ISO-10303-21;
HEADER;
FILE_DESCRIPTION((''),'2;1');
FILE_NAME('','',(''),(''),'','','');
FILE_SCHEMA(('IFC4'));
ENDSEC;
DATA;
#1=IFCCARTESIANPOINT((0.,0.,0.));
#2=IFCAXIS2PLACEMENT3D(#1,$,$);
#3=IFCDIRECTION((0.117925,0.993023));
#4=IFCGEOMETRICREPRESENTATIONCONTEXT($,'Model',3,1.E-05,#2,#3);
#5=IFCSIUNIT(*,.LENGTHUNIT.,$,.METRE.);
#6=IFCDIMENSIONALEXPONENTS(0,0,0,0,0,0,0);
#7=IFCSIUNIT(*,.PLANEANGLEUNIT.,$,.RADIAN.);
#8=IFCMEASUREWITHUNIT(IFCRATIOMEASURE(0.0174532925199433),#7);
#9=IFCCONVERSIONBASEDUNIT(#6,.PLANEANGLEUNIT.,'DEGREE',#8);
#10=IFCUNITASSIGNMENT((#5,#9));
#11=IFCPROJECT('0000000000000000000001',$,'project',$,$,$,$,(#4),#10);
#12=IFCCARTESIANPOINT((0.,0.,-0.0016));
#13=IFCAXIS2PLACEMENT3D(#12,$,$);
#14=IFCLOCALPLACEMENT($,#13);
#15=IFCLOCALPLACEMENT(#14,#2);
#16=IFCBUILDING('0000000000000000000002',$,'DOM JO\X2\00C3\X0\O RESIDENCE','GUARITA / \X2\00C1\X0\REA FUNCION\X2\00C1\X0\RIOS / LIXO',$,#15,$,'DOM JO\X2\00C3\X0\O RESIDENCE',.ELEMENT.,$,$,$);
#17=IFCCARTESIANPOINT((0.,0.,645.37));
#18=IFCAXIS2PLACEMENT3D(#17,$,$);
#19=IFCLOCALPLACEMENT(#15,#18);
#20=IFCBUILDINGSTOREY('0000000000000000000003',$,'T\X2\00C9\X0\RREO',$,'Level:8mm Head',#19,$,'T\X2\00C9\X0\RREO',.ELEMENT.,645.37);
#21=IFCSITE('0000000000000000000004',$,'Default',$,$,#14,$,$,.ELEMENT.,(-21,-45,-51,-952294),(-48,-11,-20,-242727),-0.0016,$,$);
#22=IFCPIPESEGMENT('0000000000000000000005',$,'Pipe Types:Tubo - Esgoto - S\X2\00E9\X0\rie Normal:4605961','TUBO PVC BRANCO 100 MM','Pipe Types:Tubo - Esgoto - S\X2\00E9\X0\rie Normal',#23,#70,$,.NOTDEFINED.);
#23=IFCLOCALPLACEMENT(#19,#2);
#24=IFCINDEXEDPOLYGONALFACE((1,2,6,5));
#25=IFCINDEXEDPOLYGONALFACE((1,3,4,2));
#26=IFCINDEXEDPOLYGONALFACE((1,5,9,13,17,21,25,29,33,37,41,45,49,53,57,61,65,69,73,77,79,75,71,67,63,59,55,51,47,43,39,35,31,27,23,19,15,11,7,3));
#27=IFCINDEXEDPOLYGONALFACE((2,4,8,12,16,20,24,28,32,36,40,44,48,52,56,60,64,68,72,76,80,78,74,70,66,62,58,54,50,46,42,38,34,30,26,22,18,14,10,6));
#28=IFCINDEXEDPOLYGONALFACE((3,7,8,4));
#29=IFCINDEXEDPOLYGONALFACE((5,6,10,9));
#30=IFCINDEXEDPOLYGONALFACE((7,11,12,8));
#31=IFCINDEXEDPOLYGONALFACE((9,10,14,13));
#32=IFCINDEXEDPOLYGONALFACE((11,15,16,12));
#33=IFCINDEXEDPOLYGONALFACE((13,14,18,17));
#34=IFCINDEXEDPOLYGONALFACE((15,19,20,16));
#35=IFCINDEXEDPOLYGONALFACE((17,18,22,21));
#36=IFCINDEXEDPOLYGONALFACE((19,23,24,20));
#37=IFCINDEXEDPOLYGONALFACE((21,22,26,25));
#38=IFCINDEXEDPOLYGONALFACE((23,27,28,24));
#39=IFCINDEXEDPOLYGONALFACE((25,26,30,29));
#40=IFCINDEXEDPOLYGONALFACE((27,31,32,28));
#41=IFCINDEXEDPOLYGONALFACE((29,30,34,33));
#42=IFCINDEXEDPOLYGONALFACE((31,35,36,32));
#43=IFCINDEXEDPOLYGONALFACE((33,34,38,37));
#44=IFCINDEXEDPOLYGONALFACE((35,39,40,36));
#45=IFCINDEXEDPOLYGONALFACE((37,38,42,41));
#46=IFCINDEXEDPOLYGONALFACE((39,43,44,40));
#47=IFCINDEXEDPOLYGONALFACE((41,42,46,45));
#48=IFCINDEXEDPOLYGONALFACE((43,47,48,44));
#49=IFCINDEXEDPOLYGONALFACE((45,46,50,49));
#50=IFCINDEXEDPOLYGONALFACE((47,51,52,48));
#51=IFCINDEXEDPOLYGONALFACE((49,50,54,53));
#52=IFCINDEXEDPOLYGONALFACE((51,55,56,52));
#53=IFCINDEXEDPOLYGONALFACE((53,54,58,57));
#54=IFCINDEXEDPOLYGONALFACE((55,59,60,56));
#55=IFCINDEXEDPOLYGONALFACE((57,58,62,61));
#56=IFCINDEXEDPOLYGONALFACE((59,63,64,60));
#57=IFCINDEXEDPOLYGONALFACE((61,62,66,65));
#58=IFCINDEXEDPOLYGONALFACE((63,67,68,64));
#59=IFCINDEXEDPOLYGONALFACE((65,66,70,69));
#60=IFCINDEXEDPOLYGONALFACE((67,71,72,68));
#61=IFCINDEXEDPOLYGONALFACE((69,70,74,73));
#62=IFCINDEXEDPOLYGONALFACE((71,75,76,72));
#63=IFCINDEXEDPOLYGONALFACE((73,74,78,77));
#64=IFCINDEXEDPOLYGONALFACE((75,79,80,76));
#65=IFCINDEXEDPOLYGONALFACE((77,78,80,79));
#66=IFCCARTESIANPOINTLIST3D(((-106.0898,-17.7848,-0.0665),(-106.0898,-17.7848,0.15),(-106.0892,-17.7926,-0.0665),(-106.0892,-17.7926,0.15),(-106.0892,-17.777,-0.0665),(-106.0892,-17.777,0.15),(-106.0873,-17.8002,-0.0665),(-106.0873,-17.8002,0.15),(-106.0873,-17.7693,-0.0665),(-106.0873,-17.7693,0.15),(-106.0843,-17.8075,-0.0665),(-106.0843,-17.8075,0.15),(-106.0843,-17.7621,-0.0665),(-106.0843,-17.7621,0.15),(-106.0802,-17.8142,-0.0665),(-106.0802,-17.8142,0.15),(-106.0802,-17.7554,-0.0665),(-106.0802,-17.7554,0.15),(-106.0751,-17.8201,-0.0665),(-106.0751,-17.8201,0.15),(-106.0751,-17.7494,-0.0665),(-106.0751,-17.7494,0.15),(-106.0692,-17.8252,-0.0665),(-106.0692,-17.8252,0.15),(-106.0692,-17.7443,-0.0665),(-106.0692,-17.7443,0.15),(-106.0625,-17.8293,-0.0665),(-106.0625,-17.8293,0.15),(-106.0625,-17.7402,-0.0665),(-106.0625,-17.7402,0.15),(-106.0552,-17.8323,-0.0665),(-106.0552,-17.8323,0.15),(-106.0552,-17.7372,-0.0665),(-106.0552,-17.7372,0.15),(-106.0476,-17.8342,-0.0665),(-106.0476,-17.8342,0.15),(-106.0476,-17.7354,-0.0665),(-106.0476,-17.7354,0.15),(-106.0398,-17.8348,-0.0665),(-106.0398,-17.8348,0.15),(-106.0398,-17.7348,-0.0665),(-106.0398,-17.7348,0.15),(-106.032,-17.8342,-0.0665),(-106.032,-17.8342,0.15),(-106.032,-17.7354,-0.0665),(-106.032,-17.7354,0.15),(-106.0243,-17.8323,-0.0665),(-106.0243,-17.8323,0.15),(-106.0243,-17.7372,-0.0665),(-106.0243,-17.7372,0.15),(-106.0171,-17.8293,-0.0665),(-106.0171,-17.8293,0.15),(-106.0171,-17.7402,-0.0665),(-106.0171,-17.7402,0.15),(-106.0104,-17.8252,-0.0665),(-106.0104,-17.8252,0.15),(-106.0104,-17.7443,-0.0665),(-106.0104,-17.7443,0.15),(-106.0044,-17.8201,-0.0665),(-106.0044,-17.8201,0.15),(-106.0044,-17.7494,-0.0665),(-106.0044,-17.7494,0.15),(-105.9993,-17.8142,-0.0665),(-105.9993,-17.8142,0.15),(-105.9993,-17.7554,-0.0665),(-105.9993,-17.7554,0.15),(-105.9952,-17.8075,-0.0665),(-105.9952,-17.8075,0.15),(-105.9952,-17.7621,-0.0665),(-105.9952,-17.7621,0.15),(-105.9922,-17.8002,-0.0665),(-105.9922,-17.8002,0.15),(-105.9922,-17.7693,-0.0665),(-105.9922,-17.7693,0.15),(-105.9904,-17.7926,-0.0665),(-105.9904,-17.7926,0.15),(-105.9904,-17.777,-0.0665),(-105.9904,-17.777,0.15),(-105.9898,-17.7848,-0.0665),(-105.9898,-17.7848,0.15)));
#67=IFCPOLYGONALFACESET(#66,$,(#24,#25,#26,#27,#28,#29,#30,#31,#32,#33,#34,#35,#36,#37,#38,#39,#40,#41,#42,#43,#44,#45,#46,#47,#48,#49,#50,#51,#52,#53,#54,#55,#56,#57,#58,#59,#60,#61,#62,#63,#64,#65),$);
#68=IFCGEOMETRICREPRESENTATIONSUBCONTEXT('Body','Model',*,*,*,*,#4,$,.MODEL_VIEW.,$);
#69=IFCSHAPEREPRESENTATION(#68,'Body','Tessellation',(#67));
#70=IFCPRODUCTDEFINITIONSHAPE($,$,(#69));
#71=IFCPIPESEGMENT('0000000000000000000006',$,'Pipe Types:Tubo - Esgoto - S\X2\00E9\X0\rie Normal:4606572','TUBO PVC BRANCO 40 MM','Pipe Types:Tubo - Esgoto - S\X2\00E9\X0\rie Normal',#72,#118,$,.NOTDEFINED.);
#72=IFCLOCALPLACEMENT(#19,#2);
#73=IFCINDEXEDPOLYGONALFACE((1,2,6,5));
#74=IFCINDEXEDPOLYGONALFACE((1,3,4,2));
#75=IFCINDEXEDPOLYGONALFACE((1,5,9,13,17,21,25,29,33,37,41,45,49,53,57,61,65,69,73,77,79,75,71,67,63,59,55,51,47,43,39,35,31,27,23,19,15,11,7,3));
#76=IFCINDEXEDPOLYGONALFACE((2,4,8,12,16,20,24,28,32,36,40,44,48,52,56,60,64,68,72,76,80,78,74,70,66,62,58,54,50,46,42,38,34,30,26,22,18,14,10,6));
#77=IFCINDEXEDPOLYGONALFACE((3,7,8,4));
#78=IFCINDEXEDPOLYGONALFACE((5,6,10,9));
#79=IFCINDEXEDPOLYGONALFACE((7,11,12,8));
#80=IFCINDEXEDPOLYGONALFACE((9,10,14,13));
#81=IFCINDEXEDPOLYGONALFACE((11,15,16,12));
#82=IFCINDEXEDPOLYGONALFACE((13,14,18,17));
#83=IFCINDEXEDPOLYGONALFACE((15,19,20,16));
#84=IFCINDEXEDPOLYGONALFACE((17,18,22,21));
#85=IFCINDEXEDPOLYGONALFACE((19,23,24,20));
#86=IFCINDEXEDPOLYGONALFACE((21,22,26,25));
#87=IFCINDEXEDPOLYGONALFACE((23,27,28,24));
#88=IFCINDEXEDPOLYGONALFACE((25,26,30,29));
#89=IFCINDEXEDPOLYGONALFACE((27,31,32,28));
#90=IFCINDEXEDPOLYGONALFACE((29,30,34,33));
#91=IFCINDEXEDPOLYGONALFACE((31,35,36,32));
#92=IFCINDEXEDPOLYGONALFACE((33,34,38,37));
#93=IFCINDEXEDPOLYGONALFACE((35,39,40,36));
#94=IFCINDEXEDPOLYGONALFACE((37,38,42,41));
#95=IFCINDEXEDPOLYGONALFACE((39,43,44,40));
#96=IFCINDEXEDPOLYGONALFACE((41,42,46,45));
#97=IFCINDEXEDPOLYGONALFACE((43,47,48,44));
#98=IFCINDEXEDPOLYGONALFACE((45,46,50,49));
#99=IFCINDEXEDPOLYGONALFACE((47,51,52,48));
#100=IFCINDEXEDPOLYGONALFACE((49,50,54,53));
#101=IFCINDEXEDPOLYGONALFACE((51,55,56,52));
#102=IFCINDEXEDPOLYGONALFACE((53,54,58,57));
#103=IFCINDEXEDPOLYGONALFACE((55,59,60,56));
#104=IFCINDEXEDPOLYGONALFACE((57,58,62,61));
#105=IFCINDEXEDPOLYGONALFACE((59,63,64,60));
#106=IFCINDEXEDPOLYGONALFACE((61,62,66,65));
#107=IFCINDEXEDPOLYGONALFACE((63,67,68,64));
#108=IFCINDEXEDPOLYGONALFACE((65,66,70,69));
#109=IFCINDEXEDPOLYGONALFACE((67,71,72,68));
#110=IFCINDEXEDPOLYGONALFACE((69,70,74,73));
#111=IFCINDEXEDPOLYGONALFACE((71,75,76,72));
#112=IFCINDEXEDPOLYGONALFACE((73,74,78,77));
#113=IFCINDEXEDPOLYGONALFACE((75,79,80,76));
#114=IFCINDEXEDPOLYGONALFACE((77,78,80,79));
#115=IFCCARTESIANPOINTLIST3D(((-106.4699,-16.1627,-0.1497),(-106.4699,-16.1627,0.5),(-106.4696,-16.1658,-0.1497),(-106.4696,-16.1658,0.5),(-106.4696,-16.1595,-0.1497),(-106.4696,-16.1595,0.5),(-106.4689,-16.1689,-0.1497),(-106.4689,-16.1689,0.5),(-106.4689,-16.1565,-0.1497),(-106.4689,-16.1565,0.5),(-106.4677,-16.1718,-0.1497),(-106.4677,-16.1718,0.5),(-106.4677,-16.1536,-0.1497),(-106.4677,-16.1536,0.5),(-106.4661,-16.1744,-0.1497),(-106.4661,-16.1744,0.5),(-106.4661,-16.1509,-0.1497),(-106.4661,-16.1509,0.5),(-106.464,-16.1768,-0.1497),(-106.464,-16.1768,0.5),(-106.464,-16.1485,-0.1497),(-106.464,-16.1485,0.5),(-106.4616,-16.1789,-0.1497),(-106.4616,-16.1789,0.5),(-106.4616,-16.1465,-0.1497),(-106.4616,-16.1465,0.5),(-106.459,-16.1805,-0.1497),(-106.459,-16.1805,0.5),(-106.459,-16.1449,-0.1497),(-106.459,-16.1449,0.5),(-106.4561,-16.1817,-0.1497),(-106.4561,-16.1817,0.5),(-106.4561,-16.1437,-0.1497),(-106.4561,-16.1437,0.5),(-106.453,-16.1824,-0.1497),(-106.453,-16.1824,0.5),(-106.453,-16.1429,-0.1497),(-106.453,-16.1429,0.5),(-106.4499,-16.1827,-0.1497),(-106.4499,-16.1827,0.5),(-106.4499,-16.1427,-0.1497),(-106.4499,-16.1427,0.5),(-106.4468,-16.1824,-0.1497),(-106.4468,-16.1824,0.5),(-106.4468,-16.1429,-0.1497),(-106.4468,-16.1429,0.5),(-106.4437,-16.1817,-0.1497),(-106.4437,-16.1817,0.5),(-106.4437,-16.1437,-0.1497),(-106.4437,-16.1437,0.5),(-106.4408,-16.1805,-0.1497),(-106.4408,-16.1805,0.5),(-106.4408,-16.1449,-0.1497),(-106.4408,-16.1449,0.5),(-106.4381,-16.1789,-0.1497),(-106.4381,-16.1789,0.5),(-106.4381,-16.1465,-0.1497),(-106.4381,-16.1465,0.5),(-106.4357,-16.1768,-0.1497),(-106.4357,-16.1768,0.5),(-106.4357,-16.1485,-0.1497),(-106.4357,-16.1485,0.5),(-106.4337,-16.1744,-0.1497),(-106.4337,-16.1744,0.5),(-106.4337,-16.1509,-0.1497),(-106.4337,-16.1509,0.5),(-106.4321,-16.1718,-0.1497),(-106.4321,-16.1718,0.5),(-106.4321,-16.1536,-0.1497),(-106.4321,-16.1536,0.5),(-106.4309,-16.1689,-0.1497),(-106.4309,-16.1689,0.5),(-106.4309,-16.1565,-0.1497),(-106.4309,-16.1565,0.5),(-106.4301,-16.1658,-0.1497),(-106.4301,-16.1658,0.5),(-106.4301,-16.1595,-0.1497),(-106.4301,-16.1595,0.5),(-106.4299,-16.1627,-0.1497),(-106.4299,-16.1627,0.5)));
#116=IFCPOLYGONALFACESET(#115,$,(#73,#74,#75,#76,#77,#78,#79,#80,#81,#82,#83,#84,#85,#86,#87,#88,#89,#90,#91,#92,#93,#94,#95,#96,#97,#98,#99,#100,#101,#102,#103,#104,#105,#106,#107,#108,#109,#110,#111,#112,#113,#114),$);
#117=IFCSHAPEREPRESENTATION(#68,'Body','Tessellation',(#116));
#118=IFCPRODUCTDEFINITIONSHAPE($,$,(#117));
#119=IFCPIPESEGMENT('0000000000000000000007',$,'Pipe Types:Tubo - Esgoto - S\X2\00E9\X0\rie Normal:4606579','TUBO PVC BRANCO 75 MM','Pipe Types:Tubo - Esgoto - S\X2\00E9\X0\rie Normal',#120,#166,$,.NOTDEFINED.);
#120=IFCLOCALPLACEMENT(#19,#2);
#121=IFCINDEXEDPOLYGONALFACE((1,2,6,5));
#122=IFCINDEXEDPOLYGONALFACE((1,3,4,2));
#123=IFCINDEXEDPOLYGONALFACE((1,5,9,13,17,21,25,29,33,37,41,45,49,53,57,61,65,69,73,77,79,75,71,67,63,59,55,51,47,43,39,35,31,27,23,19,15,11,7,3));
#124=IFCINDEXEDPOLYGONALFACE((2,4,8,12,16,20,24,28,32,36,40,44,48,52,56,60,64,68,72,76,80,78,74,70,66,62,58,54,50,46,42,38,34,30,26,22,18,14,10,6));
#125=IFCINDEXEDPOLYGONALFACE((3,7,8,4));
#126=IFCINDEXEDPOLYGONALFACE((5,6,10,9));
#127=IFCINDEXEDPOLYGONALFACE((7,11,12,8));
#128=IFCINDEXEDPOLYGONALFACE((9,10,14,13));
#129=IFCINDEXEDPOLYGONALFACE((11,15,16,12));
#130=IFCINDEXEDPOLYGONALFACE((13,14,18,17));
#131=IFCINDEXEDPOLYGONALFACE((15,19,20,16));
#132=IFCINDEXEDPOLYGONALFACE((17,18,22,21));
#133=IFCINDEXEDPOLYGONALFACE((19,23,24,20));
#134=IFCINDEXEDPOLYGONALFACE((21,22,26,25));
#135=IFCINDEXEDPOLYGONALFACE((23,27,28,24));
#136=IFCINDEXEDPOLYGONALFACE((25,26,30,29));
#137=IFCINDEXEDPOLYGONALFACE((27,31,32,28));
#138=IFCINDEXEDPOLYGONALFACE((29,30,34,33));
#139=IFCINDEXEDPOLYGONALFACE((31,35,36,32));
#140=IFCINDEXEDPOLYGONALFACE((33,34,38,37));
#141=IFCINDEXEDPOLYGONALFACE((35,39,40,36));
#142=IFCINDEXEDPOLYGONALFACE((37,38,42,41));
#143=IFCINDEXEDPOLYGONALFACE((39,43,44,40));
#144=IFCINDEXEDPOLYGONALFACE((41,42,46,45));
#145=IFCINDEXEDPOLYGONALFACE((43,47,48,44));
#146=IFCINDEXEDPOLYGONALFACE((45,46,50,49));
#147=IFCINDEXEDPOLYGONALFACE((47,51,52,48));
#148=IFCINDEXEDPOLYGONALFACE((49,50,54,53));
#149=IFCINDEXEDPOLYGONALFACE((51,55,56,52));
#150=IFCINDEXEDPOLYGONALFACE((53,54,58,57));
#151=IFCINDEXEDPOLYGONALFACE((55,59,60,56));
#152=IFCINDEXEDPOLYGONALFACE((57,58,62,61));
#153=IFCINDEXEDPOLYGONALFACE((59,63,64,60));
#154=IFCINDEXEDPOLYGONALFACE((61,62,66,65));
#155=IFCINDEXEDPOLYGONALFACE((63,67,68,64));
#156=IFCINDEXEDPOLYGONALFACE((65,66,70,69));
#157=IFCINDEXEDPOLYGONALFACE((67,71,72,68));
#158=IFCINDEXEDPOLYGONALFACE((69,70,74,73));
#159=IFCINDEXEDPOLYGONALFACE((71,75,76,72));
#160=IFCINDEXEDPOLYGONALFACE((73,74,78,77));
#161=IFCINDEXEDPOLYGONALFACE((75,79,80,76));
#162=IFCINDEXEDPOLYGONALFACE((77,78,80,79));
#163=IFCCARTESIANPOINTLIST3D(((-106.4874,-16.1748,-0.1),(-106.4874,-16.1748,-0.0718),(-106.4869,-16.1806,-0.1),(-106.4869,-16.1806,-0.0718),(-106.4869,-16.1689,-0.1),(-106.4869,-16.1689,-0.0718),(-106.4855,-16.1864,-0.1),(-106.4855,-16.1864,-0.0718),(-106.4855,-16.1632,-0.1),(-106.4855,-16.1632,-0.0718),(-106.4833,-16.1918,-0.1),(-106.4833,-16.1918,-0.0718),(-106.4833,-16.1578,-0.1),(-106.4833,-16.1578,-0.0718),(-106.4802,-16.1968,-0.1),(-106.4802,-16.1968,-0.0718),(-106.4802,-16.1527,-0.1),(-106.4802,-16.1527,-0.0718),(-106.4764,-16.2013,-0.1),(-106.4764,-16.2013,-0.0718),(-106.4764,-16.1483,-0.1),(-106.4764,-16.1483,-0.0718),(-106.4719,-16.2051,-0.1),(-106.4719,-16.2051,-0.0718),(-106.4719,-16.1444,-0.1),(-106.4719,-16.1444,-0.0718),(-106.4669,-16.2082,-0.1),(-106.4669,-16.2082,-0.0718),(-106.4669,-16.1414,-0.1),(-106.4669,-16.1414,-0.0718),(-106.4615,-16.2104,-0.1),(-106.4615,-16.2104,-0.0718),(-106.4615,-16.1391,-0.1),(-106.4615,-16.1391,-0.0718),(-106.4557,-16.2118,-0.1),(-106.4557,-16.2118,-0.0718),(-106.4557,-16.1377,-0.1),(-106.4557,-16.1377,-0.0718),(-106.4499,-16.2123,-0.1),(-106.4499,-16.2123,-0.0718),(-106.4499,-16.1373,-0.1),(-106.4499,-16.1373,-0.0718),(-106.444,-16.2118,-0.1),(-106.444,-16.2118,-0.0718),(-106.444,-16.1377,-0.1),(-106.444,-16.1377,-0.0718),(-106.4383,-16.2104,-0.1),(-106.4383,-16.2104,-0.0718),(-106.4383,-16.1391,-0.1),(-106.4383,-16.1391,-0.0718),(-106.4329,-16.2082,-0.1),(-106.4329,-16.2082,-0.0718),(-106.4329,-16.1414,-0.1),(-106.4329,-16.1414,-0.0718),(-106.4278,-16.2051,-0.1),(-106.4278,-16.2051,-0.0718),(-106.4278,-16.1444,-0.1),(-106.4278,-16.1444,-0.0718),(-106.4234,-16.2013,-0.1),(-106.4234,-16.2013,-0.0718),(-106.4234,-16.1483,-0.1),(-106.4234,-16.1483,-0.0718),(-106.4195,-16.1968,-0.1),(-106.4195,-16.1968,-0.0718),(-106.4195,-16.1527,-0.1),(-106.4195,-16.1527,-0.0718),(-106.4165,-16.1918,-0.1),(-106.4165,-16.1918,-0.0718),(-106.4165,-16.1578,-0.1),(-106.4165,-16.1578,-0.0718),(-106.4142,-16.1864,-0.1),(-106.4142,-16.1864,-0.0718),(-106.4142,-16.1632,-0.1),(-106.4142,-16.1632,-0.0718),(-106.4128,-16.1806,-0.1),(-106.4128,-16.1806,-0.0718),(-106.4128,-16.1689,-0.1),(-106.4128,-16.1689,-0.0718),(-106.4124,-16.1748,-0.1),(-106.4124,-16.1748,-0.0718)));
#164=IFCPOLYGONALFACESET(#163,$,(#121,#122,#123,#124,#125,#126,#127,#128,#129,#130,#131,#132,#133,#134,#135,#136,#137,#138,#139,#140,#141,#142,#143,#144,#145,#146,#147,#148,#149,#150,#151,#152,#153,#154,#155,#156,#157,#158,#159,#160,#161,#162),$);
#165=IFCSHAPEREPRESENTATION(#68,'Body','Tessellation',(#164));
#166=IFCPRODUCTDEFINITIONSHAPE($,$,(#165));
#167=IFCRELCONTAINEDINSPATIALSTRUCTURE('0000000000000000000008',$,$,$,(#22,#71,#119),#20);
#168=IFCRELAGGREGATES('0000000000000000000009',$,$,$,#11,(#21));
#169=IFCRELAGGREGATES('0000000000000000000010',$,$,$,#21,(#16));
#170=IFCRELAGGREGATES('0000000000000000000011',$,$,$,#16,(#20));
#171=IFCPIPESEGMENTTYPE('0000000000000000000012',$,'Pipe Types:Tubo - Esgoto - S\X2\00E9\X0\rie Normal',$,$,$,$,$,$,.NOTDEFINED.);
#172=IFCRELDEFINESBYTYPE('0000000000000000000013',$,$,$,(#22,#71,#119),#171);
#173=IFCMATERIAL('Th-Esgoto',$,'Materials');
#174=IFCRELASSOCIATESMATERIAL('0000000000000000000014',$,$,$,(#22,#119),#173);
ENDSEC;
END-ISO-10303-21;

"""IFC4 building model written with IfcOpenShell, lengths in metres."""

from ifc_helpers import new_model, entity, si_unit, converted_unit, direction, frame, origin, place, context, subcontext, project, spatial, indexed_curve, outline, extrude, material, type_object, element, save


model = new_model("IFC4")

# Units and contexts
model_context = context("Model", 3, precision=1e-05, world=origin(), true_north=direction((0.117925, 0.993023)))
body_context = subcontext(model_context, "Body", "Model", "MODEL_VIEW")
ifc_project = project(units=[si_unit("LENGTHUNIT", "METRE"), converted_unit("PLANEANGLEUNIT", "DEGREE", entity("IfcRatioMeasure", 0.0174532925199433), si_unit("PLANEANGLEUNIT", "RADIAN"), dimensions=[0, 0, 0, 0, 0, 0, 0])], contexts=[model_context])

# Site, building, storey
site_placement = place(None, frame((0.0, 0.0, -0.0016)))
site = spatial("IfcSite", under=ifc_project, at=site_placement, Name="Default", CompositionType="ELEMENT", RefLatitude=(-21, -45, -51, -952294), RefLongitude=(-48, -11, -20, -242727), RefElevation=-0.0016)
building_placement = place(site_placement, origin())
building = spatial("IfcBuilding", under=site, at=building_placement, Name="DOM JOÃO RESIDENCE", Description="GUARITA / ÁREA FUNCIONÁRIOS / LIXO", LongName="DOM JOÃO RESIDENCE", CompositionType="ELEMENT")
storey_placement = place(building_placement, frame((0.0, 0.0, 645.37)))
storey = spatial("IfcBuildingStorey", under=building, at=storey_placement, Name="TÉRREO", ObjectType="Level:8mm Head", LongName="TÉRREO", CompositionType="ELEMENT", Elevation=645.37)

# Pipe segments
ifc_material = material(Name="Th-Esgoto", Category="Materials")
pipe_segment_type_1 = type_object("IfcPipeSegmentType", Name="Pipe Types:Tubo - Esgoto - Série Normal", PredefinedType="NOTDEFINED")
pipe_segment_1_placement = place(storey_placement, frame((-106.0914, -17.8364, -0.0665)))
element("IfcPipeSegment", 1, at=pipe_segment_1_placement, inside=storey, type_object=pipe_segment_type_1, material=ifc_material, Name="Pipe Types:Tubo - Esgoto - Série Normal:4605961", Description="TUBO PVC BRANCO 100 MM", ObjectType="Pipe Types:Tubo - Esgoto - Série Normal", PredefinedType="NOTDEFINED", context=body_context, shape_type="SweptSolid", body=[
    extrude(outline(indexed_curve([(0.05, 0.0), (0.0494, 0.0078), (0.0476, 0.0155), (0.0446, 0.0227), (0.0405, 0.0294), (0.0354, 0.0354), (0.0294, 0.0405), (0.0227, 0.0446), (0.0155, 0.0476), (0.0078, 0.0494), (0.0, 0.05), (-0.0078, 0.0494), (-0.0155, 0.0476), (-0.0227, 0.0446), (-0.0294, 0.0405), (-0.0354, 0.0354), (-0.0405, 0.0294), (-0.0446, 0.0227), (-0.0476, 0.0155), (-0.0494, 0.0078), (-0.05, 0.0), (-0.0494, -0.0078), (-0.0476, -0.0155), (-0.0446, -0.0227), (-0.0405, -0.0294), (-0.0354, -0.0354), (-0.0294, -0.0405), (-0.0227, -0.0446), (-0.0155, -0.0476), (-0.0078, -0.0494), (0.0, -0.05), (0.0078, -0.0494), (0.0155, -0.0476), (0.0227, -0.0446), (0.0294, -0.0405), (0.0354, -0.0354), (0.0405, -0.0294), (0.0446, -0.0227), (0.0476, -0.0155), (0.0494, -0.0078), (0.05, 0.0)], self_intersect=False)), frame((0.0516, 0.0516, 0.0)), (0.0, 0.0, 1.0), 0.2165),
])
pipe_segment_2_placement = place(storey_placement, frame((-106.4715, -16.1843, -0.1497)))
element("IfcPipeSegment", 2, at=pipe_segment_2_placement, inside=storey, type_object=pipe_segment_type_1, Name="Pipe Types:Tubo - Esgoto - Série Normal:4606572", Description="TUBO PVC BRANCO 40 MM", ObjectType="Pipe Types:Tubo - Esgoto - Série Normal", PredefinedType="NOTDEFINED", context=body_context, shape_type="SweptSolid", body=[
    extrude(outline(indexed_curve([(0.02, 0.0), (0.0198, 0.0031), (0.019, 0.0062), (0.0178, 0.0091), (0.0162, 0.0118), (0.0141, 0.0141), (0.0118, 0.0162), (0.0091, 0.0178), (0.0062, 0.019), (0.0031, 0.0198), (0.0, 0.02), (-0.0031, 0.0198), (-0.0062, 0.019), (-0.0091, 0.0178), (-0.0118, 0.0162), (-0.0141, 0.0141), (-0.0162, 0.0118), (-0.0178, 0.0091), (-0.019, 0.0062), (-0.0198, 0.0031), (-0.02, 0.0), (-0.0198, -0.0031), (-0.019, -0.0062), (-0.0178, -0.0091), (-0.0162, -0.0118), (-0.0141, -0.0141), (-0.0118, -0.0162), (-0.0091, -0.0178), (-0.0062, -0.019), (-0.0031, -0.0198), (0.0, -0.02), (0.0031, -0.0198), (0.0062, -0.019), (0.0091, -0.0178), (0.0118, -0.0162), (0.0141, -0.0141), (0.0162, -0.0118), (0.0178, -0.0091), (0.019, -0.0062), (0.0198, -0.0031), (0.02, 0.0)], self_intersect=False)), frame((0.0216, 0.0216, 0.0)), (0.0, 0.0, 1.0), 0.6497),
])
pipe_segment_3_placement = place(storey_placement, frame((-106.489, -16.2139, -0.1)))
element("IfcPipeSegment", 3, at=pipe_segment_3_placement, inside=storey, type_object=pipe_segment_type_1, material=ifc_material, Name="Pipe Types:Tubo - Esgoto - Série Normal:4606579", Description="TUBO PVC BRANCO 75 MM", ObjectType="Pipe Types:Tubo - Esgoto - Série Normal", PredefinedType="NOTDEFINED", context=body_context, shape_type="SweptSolid", body=[
    extrude(outline(indexed_curve([(0.0375, 0.0), (0.037, 0.0059), (0.0357, 0.0116), (0.0334, 0.017), (0.0303, 0.022), (0.0265, 0.0265), (0.022, 0.0303), (0.017, 0.0334), (0.0116, 0.0357), (0.0059, 0.037), (0.0, 0.0375), (-0.0059, 0.037), (-0.0116, 0.0357), (-0.017, 0.0334), (-0.022, 0.0303), (-0.0265, 0.0265), (-0.0303, 0.022), (-0.0334, 0.017), (-0.0357, 0.0116), (-0.037, 0.0059), (-0.0375, 0.0), (-0.037, -0.0059), (-0.0357, -0.0116), (-0.0334, -0.017), (-0.0303, -0.022), (-0.0265, -0.0265), (-0.022, -0.0303), (-0.017, -0.0334), (-0.0116, -0.0357), (-0.0059, -0.037), (0.0, -0.0375), (0.0059, -0.037), (0.0116, -0.0357), (0.017, -0.0334), (0.022, -0.0303), (0.0265, -0.0265), (0.0303, -0.022), (0.0334, -0.017), (0.0357, -0.0116), (0.037, -0.0059), (0.0375, 0.0)], self_intersect=False)), frame((0.0391, 0.0391, 0.0)), (0.0, 0.0, 1.0), 0.0282),
])

save(model, "model.ifc")
